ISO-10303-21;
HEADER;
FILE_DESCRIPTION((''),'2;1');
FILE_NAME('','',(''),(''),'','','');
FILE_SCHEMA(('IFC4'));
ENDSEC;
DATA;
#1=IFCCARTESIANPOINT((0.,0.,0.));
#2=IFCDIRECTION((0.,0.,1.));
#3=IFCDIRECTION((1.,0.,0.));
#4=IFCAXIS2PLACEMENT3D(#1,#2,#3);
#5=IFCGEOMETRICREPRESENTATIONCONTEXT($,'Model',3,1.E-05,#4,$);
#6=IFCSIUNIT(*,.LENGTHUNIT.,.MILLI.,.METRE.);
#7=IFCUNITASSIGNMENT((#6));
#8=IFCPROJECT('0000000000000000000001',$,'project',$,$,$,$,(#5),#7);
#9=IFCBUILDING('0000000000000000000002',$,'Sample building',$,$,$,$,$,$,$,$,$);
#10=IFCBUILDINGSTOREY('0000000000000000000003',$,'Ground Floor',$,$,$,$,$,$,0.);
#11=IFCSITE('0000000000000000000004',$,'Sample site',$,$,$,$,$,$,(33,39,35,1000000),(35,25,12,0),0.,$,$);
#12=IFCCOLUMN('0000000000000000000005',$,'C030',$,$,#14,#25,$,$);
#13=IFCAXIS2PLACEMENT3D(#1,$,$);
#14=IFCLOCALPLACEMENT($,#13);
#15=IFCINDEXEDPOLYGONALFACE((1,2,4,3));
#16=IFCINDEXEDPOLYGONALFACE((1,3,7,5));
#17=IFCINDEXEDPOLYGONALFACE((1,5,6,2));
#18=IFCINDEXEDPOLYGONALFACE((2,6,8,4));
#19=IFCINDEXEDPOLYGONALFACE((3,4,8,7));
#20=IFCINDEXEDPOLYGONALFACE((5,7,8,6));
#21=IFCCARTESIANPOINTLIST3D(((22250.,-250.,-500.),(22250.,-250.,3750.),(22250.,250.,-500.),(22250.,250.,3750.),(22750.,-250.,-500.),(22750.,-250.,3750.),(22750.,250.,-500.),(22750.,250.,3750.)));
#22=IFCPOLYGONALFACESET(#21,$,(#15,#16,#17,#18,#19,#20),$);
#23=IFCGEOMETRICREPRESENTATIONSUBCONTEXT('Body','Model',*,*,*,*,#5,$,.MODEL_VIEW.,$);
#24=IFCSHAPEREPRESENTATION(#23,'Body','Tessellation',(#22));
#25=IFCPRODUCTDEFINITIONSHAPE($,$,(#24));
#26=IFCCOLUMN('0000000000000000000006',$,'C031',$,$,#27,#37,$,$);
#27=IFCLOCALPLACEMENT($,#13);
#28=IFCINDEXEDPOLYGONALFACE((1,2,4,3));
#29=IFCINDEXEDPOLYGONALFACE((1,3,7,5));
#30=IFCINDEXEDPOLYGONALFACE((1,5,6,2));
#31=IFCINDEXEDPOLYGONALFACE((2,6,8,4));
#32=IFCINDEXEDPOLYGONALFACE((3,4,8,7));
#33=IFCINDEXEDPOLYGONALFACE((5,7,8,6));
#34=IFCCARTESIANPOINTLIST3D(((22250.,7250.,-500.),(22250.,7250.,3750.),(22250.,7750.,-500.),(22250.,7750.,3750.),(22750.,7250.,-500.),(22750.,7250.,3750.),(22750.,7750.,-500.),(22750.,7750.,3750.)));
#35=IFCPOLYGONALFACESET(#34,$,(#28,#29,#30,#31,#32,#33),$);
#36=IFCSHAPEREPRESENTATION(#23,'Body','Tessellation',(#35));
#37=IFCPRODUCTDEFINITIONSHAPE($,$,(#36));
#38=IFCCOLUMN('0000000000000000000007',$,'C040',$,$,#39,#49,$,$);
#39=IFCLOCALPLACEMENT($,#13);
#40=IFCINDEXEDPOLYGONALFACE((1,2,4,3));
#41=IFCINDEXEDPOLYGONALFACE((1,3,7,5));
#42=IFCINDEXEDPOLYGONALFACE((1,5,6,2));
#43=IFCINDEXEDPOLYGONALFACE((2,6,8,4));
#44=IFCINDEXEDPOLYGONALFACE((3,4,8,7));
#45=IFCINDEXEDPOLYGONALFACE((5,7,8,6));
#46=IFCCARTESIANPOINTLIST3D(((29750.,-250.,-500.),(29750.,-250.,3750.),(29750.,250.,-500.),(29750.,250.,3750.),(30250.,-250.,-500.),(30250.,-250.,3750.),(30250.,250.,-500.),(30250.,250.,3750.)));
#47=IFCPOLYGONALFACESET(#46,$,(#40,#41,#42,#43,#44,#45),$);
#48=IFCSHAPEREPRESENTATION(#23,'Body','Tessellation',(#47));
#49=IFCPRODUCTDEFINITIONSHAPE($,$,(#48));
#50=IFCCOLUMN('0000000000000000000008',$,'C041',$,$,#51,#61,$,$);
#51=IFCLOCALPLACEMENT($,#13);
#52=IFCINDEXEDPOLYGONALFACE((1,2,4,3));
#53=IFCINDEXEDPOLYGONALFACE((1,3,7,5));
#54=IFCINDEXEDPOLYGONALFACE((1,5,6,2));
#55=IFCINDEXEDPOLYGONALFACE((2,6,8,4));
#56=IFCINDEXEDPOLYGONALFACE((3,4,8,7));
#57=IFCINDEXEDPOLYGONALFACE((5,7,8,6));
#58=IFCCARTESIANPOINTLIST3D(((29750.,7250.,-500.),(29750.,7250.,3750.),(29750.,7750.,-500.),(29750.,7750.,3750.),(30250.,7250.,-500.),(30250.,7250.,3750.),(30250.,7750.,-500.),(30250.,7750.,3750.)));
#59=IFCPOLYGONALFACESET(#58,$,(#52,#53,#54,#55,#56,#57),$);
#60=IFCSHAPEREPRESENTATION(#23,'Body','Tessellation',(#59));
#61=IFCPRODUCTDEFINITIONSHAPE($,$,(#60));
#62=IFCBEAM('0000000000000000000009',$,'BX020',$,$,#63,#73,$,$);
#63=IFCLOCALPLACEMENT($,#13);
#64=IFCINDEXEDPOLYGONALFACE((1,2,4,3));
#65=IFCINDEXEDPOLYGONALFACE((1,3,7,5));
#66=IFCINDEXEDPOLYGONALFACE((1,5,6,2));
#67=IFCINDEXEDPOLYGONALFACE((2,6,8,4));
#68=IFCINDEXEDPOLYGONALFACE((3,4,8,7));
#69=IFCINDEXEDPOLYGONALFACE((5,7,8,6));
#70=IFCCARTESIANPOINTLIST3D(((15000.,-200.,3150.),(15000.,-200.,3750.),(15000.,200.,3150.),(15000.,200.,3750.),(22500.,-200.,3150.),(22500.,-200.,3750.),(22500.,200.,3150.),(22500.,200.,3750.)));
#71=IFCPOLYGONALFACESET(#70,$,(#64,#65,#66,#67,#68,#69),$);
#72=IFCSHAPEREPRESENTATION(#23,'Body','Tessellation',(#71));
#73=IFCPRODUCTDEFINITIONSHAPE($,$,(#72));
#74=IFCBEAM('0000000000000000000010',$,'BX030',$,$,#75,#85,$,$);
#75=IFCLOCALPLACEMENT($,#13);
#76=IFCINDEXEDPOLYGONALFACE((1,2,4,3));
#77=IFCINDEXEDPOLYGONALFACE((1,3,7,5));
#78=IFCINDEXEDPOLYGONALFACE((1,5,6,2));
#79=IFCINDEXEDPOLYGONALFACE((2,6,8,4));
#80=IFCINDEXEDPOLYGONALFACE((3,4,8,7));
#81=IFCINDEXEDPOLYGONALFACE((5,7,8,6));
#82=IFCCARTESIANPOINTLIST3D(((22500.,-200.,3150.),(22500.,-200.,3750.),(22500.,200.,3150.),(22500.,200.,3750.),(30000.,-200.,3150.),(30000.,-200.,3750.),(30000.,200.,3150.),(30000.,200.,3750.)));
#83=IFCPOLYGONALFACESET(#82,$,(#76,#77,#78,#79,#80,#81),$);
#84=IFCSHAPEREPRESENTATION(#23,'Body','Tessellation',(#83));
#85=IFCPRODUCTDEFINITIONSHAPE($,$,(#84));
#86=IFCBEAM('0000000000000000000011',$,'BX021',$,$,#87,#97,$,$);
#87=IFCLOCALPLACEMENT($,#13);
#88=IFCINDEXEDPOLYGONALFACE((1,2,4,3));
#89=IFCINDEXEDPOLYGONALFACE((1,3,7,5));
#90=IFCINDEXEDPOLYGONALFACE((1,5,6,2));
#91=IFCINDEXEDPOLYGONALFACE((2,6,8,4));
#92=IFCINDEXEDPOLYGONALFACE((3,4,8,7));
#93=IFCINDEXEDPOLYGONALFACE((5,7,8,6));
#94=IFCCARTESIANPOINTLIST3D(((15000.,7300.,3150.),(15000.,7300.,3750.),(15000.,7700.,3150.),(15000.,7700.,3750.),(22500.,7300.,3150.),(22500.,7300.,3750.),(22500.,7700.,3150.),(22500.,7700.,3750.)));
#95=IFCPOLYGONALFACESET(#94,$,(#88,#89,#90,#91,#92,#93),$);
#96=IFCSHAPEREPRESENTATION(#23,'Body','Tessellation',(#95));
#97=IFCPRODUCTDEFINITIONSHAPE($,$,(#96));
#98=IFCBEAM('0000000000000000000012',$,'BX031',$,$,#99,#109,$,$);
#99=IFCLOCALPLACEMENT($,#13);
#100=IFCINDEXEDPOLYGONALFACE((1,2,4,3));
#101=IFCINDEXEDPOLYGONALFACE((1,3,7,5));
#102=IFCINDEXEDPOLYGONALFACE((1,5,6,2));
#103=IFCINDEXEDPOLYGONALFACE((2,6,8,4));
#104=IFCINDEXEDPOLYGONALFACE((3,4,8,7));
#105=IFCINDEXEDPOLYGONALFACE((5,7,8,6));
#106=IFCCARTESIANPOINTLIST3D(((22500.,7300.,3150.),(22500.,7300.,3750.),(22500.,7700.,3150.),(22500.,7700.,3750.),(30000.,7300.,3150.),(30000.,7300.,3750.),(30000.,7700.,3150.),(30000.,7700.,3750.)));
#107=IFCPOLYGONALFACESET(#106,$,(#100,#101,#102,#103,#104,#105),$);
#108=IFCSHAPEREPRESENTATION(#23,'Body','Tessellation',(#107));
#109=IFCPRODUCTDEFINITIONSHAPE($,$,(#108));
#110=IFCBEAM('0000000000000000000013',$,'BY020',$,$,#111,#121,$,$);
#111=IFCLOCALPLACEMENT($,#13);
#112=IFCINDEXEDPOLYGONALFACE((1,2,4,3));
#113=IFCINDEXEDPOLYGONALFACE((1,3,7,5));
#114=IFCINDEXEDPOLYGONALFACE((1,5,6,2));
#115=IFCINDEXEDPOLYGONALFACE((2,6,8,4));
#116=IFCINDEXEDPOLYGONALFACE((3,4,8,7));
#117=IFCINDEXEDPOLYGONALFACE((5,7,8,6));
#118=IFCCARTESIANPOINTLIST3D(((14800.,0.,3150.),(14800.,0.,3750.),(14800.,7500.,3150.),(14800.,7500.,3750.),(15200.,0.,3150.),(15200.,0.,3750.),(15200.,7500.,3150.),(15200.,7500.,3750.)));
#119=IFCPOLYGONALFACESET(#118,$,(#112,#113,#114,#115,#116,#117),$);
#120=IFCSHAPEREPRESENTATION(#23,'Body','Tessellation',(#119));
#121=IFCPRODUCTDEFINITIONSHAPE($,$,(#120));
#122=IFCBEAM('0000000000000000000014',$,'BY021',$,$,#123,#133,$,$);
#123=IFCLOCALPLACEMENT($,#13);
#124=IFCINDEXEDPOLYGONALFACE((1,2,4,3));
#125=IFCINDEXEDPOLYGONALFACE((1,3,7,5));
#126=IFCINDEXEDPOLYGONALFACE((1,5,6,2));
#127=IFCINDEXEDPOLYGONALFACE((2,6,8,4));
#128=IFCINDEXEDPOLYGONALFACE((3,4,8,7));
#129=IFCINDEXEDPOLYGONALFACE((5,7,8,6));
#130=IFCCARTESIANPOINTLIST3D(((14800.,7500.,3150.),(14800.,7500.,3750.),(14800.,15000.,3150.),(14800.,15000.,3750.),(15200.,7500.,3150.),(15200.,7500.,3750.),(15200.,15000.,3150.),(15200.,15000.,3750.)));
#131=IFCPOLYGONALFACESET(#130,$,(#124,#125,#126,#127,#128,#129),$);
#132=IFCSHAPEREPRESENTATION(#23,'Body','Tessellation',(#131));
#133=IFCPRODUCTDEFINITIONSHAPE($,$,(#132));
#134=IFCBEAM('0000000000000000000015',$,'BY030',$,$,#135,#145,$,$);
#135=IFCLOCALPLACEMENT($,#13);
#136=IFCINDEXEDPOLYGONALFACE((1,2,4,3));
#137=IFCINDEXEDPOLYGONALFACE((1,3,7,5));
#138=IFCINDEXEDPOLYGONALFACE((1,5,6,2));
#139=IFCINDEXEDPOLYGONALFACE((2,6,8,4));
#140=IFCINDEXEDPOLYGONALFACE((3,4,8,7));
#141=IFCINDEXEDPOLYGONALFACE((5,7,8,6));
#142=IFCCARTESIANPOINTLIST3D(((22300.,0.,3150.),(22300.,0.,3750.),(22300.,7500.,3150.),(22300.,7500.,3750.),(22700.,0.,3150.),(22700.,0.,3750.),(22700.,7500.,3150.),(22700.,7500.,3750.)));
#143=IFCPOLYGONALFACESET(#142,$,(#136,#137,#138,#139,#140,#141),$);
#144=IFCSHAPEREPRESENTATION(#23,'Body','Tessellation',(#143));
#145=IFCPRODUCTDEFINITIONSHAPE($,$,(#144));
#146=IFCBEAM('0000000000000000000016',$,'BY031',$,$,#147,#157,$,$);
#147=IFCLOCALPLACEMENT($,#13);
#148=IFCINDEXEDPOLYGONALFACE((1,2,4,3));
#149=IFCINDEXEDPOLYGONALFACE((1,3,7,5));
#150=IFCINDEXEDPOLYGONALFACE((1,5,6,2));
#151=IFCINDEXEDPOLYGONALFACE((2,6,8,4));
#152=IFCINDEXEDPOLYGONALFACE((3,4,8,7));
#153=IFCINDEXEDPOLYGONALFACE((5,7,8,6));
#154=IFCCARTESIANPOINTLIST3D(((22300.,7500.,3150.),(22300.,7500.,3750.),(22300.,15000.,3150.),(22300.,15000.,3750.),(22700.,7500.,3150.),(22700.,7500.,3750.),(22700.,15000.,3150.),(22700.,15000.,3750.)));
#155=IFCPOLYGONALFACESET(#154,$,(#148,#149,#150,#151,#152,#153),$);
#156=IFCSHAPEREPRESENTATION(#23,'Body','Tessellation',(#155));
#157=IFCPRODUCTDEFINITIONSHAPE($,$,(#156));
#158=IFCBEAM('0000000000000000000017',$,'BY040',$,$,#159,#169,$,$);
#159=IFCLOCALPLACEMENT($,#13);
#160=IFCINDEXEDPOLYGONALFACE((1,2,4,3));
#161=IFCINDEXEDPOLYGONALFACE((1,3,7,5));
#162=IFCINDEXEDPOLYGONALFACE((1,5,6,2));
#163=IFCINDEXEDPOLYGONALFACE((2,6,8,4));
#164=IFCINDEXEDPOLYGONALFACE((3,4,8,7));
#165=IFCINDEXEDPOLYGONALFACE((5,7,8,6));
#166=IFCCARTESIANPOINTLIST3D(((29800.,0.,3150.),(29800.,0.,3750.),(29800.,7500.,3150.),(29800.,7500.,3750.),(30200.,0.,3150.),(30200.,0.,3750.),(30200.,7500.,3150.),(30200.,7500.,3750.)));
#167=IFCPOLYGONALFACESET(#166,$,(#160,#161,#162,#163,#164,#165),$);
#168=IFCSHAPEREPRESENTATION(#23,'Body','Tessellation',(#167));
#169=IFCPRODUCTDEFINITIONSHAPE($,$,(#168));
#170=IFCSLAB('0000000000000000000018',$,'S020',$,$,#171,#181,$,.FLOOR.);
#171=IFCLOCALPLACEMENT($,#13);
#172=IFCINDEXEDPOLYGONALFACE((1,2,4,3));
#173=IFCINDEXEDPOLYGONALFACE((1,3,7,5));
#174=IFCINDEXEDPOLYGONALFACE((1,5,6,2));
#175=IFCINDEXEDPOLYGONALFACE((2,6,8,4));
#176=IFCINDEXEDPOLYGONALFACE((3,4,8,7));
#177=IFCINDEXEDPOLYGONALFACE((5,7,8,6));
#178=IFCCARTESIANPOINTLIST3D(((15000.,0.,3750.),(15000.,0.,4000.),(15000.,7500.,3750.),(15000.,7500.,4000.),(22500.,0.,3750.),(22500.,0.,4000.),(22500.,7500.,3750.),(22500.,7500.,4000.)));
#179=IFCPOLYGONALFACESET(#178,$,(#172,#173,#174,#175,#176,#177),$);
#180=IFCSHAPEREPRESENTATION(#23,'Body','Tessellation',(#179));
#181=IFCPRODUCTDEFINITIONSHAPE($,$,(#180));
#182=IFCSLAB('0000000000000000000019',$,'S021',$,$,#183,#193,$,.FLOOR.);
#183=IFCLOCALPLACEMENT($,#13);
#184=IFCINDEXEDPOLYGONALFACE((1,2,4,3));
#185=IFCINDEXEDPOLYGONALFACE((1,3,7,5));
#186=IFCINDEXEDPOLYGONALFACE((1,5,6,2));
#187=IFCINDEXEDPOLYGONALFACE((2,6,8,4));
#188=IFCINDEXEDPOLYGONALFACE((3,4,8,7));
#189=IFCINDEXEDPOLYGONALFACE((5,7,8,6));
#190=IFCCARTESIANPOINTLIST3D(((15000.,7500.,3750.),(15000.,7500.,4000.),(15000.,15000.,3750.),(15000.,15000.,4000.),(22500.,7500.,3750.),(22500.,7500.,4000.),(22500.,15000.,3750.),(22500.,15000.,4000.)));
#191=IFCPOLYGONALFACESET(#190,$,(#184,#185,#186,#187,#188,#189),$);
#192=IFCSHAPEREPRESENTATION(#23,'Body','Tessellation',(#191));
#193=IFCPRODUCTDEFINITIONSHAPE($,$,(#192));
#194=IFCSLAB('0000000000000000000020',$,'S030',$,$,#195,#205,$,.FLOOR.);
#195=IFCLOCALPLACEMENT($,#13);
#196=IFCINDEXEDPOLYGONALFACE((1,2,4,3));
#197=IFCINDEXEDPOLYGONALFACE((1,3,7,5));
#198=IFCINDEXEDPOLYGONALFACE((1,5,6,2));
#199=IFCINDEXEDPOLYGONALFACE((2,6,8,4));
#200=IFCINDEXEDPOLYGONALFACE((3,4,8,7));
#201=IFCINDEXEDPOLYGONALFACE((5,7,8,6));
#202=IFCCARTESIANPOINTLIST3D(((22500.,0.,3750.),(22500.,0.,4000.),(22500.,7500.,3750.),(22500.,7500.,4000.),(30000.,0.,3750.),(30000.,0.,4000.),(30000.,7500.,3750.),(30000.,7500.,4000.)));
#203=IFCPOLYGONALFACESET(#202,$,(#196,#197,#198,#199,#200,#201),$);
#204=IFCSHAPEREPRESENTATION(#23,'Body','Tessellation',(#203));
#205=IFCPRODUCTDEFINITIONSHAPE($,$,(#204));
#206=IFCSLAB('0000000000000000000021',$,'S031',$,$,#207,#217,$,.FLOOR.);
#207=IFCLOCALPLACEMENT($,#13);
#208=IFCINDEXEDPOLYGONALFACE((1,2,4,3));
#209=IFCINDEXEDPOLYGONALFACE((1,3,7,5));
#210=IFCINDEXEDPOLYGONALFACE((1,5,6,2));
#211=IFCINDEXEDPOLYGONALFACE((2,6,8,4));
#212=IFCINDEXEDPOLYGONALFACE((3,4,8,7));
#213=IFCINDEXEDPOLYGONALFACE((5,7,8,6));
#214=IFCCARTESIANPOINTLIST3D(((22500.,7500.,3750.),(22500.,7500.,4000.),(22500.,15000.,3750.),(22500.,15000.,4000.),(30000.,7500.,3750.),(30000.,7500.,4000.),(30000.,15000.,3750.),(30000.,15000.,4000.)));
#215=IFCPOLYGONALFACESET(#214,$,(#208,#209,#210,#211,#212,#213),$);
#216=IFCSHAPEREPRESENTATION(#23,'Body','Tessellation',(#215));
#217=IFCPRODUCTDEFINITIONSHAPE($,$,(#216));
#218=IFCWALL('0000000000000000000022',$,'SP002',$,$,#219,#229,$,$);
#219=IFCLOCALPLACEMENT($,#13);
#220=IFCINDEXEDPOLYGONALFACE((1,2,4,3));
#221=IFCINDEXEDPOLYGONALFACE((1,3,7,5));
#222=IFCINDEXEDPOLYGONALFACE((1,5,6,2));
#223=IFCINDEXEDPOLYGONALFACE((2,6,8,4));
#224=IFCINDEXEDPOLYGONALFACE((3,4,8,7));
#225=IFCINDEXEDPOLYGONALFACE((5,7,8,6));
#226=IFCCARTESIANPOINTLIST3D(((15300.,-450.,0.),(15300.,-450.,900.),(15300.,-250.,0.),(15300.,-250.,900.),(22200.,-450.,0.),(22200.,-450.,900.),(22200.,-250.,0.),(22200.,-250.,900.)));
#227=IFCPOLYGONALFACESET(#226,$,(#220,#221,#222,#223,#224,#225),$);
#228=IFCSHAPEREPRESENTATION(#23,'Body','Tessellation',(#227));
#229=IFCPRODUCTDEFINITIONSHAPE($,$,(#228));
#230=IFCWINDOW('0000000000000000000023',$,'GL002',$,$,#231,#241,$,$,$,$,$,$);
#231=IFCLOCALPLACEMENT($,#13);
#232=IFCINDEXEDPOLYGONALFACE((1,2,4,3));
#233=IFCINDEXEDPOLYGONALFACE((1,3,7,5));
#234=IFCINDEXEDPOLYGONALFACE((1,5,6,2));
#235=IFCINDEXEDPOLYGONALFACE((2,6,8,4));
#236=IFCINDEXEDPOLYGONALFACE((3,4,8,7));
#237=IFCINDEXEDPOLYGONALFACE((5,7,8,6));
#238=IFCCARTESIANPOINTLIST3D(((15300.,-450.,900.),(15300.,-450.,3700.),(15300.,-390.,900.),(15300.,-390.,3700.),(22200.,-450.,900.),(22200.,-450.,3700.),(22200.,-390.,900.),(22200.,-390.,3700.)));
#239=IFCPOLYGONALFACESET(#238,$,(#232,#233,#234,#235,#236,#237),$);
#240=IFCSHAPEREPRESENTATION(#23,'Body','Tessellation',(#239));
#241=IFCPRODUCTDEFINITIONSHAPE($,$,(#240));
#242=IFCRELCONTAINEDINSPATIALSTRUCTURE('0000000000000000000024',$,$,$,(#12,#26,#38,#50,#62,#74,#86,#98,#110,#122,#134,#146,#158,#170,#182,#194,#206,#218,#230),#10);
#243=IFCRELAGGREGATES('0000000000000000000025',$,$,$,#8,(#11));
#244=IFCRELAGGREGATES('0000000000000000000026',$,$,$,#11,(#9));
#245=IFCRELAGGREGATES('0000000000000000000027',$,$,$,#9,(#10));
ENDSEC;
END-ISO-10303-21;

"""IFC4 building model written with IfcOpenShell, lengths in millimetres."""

from ifc_helpers import new_model, si_unit, frame, origin_with_axes, place, context, subcontext, project, spatial, indexed_curve, outline, extrude, element, save


model = new_model("IFC4")

# Units and contexts
model_context = context("Model", 3, precision=1e-05, world=origin_with_axes())
body_context = subcontext(model_context, "Body", "Model", "MODEL_VIEW")
ifc_project = project(units=[si_unit("LENGTHUNIT", "METRE", prefix="MILLI")], contexts=[model_context])

# Site, building, storey
site = spatial("IfcSite", under=ifc_project, Name="Sample site", RefLatitude=(33, 39, 35, 1000000), RefLongitude=(35, 25, 12, 0), RefElevation=0.0)
building = spatial("IfcBuilding", under=site, Name="Sample building")
storey = spatial("IfcBuildingStorey", under=building, Name="Ground Floor", Elevation=0.0)

# Columns
for number, where, z_axis, x_axis, name in (
    (1, (22250.0, -250.0, -500.0), (0.0, 0.0, 1.0), (1.0, 0.0, 0.0), "C030"),
    (2, (22250.0, 7250.0, -500.0), (0.0, 0.0, 1.0), (1.0, 0.0, 0.0), "C031"),
    (3, (29750.0, -250.0, -500.0), (0.0, 0.0, 1.0), (1.0, 0.0, 0.0), "C040"),
    (4, (29750.0, 7250.0, -500.0), (0.0, 0.0, 1.0), (1.0, 0.0, 0.0), "C041"),
):
    element("IfcColumn", number, at=place(None, frame(where, z_axis=z_axis, x_axis=x_axis)), inside=storey, Name=name, context=body_context, shape_type="SweptSolid", body=[
        extrude(outline(indexed_curve([(0.0, 0.0), (0.0, 500.0), (500.0, 500.0), (500.0, 0.0), (0.0, 0.0)], self_intersect=False)), origin_with_axes(), (0.0, 0.0, 1.0), 4250.0),
    ])

# Beams
for number, where, z_axis, x_axis, name in (
    (5, (15000.0, -200.0, 3150.0), (0.0, 0.0, 1.0), (1.0, 0.0, 0.0), "BX020"),
    (6, (22500.0, -200.0, 3150.0), (0.0, 0.0, 1.0), (1.0, 0.0, 0.0), "BX030"),
    (7, (15000.0, 7300.0, 3150.0), (0.0, 0.0, 1.0), (1.0, 0.0, 0.0), "BX021"),
    (8, (22500.0, 7300.0, 3150.0), (0.0, 0.0, 1.0), (1.0, 0.0, 0.0), "BX031"),
    (9, (15200.0, 0.0, 3150.0), (0.0, 0.0, 1.0), (0.0, 1.0, 0.0), "BY020"),
    (10, (15200.0, 7500.0, 3150.0), (0.0, 0.0, 1.0), (0.0, 1.0, 0.0), "BY021"),
    (11, (22700.0, 0.0, 3150.0), (0.0, 0.0, 1.0), (0.0, 1.0, 0.0), "BY030"),
    (12, (22700.0, 7500.0, 3150.0), (0.0, 0.0, 1.0), (0.0, 1.0, 0.0), "BY031"),
    (13, (30200.0, 0.0, 3150.0), (0.0, 0.0, 1.0), (0.0, 1.0, 0.0), "BY040"),
):
    element("IfcBeam", number, at=place(None, frame(where, z_axis=z_axis, x_axis=x_axis)), inside=storey, Name=name, context=body_context, shape_type="SweptSolid", body=[
        extrude(outline(indexed_curve([(0.0, 0.0), (0.0, 400.0), (7500.0, 400.0), (7500.0, 0.0), (0.0, 0.0)], self_intersect=False)), origin_with_axes(), (0.0, 0.0, 1.0), 600.0),
    ])

# Slabs
for number, where, z_axis, x_axis, name in (
    (14, (15000.0, 0.0, 3750.0), (0.0, 0.0, 1.0), (1.0, 0.0, 0.0), "S020"),
    (15, (15000.0, 7500.0, 3750.0), (0.0, 0.0, 1.0), (1.0, 0.0, 0.0), "S021"),
    (16, (22500.0, 0.0, 3750.0), (0.0, 0.0, 1.0), (1.0, 0.0, 0.0), "S030"),
    (17, (22500.0, 7500.0, 3750.0), (0.0, 0.0, 1.0), (1.0, 0.0, 0.0), "S031"),
):
    element("IfcSlab", number, at=place(None, frame(where, z_axis=z_axis, x_axis=x_axis)), inside=storey, Name=name, PredefinedType="FLOOR", context=body_context, shape_type="SweptSolid", body=[
        extrude(outline(indexed_curve([(0.0, 0.0), (0.0, 7500.0), (7500.0, 7500.0), (7500.0, 0.0), (0.0, 0.0)], self_intersect=False)), origin_with_axes(), (0.0, 0.0, 1.0), 250.0),
    ])

# Wall
wall_1_placement = place(None, frame((15300.0, -450.0, 0.0), z_axis=(0.0, 0.0, 1.0), x_axis=(1.0, 0.0, 0.0)))
element("IfcWall", 18, at=wall_1_placement, inside=storey, Name="SP002", context=body_context, shape_type="SweptSolid", body=[
    extrude(outline(indexed_curve([(0.0, 0.0), (0.0, 200.0), (6900.0, 200.0), (6900.0, 0.0), (0.0, 0.0)], self_intersect=False)), origin_with_axes(), (0.0, 0.0, 1.0), 900.0),
])

# Window
window_1_placement = place(None, frame((15300.0, -450.0, 900.0), z_axis=(0.0, 0.0, 1.0), x_axis=(1.0, 0.0, 0.0)))
element("IfcWindow", 19, at=window_1_placement, inside=storey, Name="GL002", context=body_context, shape_type="SweptSolid", body=[
    extrude(outline(indexed_curve([(0.0, 0.0), (0.0, 60.0), (6900.0, 60.0), (6900.0, 0.0), (0.0, 0.0)], self_intersect=False)), origin_with_axes(), (0.0, 0.0, 1.0), 2800.0),
])

save(model, "model.ifc")
